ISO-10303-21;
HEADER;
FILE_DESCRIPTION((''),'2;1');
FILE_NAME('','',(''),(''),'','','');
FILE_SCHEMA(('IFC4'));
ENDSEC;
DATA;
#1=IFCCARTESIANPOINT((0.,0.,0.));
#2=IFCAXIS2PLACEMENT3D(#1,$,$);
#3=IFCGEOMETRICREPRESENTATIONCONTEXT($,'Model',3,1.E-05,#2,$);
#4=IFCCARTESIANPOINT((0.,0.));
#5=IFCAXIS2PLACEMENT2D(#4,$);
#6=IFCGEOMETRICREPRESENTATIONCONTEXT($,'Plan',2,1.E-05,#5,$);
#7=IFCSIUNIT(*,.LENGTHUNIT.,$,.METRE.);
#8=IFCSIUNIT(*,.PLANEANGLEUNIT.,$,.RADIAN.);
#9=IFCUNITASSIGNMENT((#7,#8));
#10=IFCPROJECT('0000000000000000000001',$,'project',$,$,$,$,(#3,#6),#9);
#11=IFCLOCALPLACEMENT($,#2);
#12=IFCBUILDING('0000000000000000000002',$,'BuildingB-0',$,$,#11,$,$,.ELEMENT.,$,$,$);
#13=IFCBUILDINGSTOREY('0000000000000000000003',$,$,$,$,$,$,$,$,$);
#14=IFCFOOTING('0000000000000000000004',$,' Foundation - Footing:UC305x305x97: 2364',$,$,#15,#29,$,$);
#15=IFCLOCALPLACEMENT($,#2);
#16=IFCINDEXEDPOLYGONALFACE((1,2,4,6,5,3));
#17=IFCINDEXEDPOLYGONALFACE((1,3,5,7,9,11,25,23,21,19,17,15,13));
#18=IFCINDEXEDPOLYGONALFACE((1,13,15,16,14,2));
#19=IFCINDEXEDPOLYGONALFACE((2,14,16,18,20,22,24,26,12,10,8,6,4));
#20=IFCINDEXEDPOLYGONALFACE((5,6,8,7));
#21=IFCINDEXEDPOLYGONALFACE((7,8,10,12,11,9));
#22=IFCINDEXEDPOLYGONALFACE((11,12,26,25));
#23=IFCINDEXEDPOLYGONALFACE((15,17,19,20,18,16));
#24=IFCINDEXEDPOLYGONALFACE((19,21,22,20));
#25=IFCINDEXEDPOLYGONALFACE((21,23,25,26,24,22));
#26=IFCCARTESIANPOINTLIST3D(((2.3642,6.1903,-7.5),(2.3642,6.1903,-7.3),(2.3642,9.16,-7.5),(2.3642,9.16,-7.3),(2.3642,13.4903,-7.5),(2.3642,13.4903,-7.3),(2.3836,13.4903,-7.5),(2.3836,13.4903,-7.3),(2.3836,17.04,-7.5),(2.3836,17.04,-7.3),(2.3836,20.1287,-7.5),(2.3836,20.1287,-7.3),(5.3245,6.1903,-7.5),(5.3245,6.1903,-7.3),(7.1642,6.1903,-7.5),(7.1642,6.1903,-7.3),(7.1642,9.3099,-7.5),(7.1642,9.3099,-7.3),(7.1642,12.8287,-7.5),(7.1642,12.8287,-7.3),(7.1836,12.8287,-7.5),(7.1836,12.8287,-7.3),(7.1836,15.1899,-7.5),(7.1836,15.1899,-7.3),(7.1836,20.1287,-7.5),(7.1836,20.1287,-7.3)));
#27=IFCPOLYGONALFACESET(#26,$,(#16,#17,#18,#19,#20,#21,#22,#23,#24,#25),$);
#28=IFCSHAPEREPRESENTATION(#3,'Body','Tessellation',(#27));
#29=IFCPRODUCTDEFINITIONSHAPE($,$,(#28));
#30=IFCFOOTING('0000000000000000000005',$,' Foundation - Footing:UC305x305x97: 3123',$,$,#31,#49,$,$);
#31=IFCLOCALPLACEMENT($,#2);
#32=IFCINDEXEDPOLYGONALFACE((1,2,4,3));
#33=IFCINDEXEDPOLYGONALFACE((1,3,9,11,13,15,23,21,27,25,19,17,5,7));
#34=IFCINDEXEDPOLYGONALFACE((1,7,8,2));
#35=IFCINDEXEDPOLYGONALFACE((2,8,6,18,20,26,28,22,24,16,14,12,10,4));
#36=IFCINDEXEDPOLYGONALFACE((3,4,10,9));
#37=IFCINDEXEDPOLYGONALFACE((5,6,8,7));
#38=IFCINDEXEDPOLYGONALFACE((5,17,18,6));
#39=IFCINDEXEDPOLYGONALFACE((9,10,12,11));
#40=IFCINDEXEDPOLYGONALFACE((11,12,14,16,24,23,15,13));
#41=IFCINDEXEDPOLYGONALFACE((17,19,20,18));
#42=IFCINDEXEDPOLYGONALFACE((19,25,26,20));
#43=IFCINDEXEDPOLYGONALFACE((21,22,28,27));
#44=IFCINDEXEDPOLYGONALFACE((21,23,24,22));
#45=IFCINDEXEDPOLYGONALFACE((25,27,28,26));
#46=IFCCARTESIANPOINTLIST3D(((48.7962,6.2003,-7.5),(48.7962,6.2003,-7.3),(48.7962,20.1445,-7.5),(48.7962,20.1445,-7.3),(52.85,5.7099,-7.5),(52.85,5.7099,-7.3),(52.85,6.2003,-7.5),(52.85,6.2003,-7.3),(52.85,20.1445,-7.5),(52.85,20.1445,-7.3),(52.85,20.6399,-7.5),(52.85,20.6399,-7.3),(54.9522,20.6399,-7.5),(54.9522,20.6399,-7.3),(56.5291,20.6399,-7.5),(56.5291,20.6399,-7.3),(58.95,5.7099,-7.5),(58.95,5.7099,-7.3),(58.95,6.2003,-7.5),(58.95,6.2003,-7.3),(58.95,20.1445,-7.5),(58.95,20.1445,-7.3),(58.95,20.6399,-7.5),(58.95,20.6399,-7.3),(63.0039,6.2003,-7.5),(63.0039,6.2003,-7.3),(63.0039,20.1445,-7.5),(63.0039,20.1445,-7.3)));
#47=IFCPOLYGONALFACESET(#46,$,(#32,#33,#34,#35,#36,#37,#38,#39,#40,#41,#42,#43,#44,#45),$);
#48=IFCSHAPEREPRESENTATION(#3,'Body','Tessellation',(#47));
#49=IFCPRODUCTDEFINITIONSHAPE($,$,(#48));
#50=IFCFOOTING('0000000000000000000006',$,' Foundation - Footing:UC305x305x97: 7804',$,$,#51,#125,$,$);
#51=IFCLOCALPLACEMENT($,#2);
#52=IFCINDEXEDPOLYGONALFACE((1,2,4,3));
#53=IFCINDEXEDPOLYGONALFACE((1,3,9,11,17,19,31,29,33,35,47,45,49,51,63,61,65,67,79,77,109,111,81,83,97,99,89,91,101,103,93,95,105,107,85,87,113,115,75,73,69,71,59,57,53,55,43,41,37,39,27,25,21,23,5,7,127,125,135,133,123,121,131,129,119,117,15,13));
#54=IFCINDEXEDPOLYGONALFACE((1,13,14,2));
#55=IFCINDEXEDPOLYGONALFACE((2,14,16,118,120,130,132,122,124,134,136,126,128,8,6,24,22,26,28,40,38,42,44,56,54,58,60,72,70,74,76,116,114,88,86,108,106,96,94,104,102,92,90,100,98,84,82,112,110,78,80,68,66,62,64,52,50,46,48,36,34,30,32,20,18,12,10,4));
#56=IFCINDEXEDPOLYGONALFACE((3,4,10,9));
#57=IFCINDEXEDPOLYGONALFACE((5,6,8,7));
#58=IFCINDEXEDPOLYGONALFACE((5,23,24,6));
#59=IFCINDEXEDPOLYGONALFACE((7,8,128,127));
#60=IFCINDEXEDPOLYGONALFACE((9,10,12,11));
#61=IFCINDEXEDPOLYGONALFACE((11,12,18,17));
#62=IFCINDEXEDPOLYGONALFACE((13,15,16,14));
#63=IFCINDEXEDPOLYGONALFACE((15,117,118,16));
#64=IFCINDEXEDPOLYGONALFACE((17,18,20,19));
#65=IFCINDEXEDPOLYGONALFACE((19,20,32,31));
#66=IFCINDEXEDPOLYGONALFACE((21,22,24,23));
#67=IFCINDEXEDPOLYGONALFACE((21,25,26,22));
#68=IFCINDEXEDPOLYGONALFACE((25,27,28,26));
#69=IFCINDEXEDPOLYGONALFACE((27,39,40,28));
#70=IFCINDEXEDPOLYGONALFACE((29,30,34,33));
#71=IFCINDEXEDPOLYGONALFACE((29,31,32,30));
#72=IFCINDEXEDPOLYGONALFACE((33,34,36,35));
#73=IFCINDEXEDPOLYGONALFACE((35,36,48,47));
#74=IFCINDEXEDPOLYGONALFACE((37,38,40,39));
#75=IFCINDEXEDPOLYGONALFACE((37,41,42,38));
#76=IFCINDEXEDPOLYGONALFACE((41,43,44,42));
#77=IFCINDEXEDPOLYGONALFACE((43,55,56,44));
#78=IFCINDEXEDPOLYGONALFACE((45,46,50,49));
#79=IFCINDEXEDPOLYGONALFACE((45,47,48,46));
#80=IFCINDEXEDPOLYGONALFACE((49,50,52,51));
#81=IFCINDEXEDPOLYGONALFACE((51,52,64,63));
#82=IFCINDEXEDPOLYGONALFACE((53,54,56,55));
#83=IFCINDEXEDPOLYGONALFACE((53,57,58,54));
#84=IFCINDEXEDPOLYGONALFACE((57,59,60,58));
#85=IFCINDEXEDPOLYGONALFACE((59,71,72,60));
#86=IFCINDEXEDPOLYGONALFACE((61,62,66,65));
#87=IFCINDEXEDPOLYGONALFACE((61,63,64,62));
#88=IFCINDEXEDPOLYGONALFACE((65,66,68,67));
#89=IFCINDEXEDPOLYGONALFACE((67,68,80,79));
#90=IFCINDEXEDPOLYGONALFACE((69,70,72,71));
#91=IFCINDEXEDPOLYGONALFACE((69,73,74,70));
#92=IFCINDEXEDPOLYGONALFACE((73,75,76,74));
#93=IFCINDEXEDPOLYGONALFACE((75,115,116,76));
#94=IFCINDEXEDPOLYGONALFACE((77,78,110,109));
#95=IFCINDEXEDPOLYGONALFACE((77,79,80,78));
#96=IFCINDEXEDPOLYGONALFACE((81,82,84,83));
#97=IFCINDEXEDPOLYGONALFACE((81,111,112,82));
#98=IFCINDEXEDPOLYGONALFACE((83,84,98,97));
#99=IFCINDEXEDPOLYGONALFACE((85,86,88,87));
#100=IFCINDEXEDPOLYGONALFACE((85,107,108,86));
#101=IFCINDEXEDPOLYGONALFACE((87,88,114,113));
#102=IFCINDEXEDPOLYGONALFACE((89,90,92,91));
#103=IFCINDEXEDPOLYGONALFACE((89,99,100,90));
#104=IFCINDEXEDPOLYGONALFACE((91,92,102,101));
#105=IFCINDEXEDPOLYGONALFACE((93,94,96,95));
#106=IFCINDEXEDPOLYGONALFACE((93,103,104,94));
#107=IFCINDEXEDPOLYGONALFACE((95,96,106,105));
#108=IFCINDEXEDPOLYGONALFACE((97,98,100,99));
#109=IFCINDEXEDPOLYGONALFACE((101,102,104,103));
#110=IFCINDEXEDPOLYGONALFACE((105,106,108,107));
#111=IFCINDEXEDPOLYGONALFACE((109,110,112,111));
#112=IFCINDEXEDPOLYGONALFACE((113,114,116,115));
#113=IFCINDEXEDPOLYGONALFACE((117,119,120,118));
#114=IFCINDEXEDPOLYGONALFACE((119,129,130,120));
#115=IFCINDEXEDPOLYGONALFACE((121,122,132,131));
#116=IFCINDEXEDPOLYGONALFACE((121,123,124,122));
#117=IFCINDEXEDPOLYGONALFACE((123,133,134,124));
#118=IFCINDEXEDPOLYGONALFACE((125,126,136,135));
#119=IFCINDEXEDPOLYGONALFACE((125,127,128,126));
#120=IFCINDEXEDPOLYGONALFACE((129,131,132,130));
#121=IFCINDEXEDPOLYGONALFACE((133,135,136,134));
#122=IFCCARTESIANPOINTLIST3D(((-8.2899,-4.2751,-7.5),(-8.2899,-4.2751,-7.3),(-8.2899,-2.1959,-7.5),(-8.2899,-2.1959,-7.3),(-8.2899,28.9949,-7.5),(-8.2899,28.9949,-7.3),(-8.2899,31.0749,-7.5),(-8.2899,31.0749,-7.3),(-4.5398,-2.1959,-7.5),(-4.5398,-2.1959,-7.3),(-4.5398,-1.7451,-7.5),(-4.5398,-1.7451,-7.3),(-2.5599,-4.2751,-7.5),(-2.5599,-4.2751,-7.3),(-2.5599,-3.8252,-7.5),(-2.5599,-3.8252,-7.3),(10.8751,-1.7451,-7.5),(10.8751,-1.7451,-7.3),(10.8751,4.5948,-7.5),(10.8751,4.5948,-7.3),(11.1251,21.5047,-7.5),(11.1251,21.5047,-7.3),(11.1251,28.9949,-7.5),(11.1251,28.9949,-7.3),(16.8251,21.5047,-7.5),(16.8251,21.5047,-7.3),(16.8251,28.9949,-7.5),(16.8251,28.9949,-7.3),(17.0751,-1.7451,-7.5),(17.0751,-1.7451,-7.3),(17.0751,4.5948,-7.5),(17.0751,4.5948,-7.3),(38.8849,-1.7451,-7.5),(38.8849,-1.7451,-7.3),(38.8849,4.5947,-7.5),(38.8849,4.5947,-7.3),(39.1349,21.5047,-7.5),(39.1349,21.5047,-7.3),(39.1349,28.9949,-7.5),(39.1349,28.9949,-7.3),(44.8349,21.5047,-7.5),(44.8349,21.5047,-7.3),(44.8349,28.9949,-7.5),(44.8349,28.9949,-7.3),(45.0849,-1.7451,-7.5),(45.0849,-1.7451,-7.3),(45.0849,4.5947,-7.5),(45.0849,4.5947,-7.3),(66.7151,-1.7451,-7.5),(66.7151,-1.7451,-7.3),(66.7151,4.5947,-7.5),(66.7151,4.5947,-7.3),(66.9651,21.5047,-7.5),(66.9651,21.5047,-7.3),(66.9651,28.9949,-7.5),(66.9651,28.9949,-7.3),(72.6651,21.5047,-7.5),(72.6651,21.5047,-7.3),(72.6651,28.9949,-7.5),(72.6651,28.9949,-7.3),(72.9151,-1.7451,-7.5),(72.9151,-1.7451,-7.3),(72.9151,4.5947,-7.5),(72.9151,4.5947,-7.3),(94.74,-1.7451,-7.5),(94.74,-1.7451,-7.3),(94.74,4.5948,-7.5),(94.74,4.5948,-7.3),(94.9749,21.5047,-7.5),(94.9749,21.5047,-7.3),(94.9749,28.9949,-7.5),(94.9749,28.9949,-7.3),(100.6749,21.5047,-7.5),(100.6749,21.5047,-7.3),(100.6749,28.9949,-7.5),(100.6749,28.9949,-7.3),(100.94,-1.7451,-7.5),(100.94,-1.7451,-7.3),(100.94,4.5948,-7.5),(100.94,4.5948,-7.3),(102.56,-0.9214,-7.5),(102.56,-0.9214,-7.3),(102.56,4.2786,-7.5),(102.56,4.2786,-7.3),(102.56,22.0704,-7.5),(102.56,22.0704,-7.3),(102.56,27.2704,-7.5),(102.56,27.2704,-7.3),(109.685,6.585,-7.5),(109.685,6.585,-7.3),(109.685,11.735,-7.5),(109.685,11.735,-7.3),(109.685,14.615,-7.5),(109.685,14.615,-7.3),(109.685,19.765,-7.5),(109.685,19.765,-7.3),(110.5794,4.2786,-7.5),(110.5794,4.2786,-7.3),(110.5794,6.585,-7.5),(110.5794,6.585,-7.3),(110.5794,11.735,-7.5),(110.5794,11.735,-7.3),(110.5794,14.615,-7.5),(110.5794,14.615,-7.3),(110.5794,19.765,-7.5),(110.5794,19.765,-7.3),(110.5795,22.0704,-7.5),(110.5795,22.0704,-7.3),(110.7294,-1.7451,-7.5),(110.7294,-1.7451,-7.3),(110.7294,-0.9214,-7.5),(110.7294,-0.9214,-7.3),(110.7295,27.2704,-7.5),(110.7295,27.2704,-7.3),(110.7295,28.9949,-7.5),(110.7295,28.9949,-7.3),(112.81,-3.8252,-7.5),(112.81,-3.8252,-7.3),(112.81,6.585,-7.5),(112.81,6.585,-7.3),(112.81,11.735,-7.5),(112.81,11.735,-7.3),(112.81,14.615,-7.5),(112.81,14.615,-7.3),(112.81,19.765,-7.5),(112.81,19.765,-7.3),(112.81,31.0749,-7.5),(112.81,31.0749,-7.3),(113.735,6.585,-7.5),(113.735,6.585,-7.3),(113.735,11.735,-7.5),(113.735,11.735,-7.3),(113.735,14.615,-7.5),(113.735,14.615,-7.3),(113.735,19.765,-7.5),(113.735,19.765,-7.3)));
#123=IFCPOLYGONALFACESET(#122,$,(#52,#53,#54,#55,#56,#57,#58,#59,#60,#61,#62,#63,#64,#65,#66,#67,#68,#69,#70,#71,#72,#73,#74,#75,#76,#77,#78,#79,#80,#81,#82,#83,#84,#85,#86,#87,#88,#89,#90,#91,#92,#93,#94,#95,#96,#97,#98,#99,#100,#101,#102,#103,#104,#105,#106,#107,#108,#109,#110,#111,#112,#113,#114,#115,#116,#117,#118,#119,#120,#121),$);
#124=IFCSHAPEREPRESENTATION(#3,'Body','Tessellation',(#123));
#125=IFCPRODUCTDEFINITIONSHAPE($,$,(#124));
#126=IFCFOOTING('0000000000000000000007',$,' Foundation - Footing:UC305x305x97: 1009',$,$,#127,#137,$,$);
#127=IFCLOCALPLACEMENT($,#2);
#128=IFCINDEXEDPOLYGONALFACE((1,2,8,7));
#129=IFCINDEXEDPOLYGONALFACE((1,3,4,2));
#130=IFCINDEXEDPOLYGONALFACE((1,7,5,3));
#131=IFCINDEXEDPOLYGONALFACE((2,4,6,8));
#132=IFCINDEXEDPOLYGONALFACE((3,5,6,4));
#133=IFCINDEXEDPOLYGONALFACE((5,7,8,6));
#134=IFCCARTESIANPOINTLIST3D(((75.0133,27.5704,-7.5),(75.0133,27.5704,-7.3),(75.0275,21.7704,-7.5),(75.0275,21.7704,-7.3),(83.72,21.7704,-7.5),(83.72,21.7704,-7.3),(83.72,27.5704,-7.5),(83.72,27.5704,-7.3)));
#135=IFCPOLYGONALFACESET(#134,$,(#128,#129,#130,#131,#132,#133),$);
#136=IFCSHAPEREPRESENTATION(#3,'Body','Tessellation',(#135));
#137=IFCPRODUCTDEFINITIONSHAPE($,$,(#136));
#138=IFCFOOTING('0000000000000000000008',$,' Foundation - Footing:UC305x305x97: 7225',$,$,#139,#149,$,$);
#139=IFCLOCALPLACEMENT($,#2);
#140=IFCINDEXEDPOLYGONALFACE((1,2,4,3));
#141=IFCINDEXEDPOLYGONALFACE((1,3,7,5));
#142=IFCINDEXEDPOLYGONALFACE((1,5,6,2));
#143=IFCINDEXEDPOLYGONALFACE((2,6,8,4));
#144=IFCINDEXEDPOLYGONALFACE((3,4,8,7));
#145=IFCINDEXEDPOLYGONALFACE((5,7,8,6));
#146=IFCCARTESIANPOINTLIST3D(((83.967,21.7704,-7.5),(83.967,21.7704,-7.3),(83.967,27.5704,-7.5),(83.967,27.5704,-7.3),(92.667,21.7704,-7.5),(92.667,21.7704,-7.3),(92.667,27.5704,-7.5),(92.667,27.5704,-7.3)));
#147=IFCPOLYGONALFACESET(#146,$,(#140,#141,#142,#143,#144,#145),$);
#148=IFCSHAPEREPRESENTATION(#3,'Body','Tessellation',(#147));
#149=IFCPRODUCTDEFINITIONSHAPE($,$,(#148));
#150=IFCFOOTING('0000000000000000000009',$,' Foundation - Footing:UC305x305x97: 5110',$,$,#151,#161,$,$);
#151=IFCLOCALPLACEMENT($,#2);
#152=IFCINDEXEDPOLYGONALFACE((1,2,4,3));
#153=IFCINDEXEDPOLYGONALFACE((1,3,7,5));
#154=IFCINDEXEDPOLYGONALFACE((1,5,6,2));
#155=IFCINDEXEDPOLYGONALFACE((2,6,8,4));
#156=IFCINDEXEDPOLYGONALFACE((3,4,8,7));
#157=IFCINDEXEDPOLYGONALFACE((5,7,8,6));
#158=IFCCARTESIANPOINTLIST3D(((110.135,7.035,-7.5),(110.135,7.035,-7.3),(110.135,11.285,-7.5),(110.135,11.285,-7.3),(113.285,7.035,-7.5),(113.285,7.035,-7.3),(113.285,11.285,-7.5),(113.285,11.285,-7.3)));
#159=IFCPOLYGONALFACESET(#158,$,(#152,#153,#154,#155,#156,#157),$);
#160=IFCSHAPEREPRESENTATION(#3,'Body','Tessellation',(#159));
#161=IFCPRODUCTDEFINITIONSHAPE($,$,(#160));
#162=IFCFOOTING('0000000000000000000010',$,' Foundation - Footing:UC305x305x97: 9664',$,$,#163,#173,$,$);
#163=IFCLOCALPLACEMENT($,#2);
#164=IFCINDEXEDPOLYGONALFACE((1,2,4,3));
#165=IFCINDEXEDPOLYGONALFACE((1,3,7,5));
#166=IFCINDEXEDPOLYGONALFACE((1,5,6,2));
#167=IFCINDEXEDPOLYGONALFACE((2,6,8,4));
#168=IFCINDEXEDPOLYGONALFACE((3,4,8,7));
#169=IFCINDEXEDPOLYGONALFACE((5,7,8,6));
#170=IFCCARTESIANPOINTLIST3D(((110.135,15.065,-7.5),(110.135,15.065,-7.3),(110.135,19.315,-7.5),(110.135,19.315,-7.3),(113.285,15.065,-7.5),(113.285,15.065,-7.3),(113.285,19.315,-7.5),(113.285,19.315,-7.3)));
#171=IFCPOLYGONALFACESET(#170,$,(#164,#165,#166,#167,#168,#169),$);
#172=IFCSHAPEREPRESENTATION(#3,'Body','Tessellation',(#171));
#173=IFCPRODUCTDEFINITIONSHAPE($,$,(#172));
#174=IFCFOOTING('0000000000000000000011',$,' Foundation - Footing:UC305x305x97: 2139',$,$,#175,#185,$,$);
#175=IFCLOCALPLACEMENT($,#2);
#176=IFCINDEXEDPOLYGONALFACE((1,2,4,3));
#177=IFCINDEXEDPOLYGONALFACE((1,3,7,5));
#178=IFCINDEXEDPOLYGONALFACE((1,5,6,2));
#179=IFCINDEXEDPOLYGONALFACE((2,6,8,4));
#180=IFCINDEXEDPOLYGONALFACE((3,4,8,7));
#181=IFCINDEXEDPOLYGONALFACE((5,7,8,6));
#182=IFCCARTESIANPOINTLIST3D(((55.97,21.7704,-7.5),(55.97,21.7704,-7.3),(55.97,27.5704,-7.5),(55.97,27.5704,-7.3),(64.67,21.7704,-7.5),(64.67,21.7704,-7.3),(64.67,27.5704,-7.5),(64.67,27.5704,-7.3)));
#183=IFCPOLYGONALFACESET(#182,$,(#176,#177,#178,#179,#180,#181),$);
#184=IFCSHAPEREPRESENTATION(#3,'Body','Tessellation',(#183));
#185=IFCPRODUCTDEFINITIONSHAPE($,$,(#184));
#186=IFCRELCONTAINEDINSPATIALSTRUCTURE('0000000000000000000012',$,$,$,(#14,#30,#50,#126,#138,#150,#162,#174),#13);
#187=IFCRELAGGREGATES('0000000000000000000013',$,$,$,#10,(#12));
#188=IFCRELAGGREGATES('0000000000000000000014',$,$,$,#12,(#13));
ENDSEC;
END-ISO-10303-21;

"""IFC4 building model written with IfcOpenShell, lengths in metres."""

from ifc_helpers import new_model, si_unit, origin, origin_2d, place, context, project, spatial, polyline, outline, extrude, element, save


model = new_model("IFC4")

# Units and contexts
model_context = context("Model", 3, precision=1e-05, world=origin())
plan_context = context("Plan", 2, precision=1e-05, world=origin_2d())
ifc_project = project(units=[si_unit("LENGTHUNIT", "METRE"), si_unit("PLANEANGLEUNIT", "RADIAN")], contexts=[model_context, plan_context])

# Building, storey
building_placement = place(None, origin())
building = spatial("IfcBuilding", under=ifc_project, at=building_placement, Name="BuildingB-0", CompositionType="ELEMENT")
storey = spatial("IfcBuildingStorey", under=building)

# Footings
element("IfcFooting", 1, inside=storey, Name=" Foundation - Footing:UC305x305x97: 2364", context=model_context, shape_type="SweptSolid", body=[
    extrude(outline(polyline([(7.1642, 12.8287, -7.5), (7.1836, 12.8287, -7.5), (7.1836, 15.1899, -7.5), (7.1836, 20.1287, -7.5), (2.3836, 20.1287, -7.5), (2.3836, 17.04, -7.5), (2.3836, 13.4903, -7.5), (2.3642, 13.4903, -7.5), (2.3642, 9.16, -7.5), (2.3642, 6.1903, -7.5), (5.3245, 6.1903, -7.5), (7.1642, 6.1903, -7.5), (7.1642, 9.3099, -7.5), (7.1642, 12.8287, -7.5)])), None, (0.0, 0.0, 1.0), 0.2),
])
element("IfcFooting", 2, inside=storey, Name=" Foundation - Footing:UC305x305x97: 3123", context=model_context, shape_type="SweptSolid", body=[
    extrude(outline(polyline([(58.95, 5.7099, -7.5), (58.95, 6.2003, -7.5), (63.0039, 6.2003, -7.5), (63.0039, 20.1445, -7.5), (58.95, 20.1445, -7.5), (58.95, 20.6399, -7.5), (56.5291, 20.6399, -7.5), (54.9522, 20.6399, -7.5), (52.85, 20.6399, -7.5), (52.85, 20.1445, -7.5), (48.7962, 20.1445, -7.5), (48.7962, 6.2003, -7.5), (52.85, 6.2003, -7.5), (52.85, 5.7099, -7.5), (58.95, 5.7099, -7.5)])), None, (0.0, 0.0, 1.0), 0.2),
])
element("IfcFooting", 3, inside=storey, Name=" Foundation - Footing:UC305x305x97: 7804", context=model_context, shape_type="SweptSolid", body=[
    extrude(outline(polyline([(-8.2899, 31.0749, -7.5), (-8.2899, 28.9949, -7.5), (11.1251, 28.9949, -7.5), (11.1251, 21.5047, -7.5), (16.8251, 21.5047, -7.5), (16.8251, 28.9949, -7.5), (39.1349, 28.9949, -7.5), (39.1349, 21.5047, -7.5), (44.8349, 21.5047, -7.5), (44.8349, 28.9949, -7.5), (66.9651, 28.9949, -7.5), (66.9651, 21.5047, -7.5), (72.6651, 21.5047, -7.5), (72.6651, 28.9949, -7.5), (94.9749, 28.9949, -7.5), (94.9749, 21.5047, -7.5), (100.6749, 21.5047, -7.5), (100.6749, 28.9949, -7.5), (110.7295, 28.9949, -7.5), (110.7295, 27.2704, -7.5), (102.56, 27.2704, -7.5), (102.56, 22.0704, -7.5), (110.5795, 22.0704, -7.5), (110.5794, 19.765, -7.5), (109.685, 19.765, -7.5), (109.685, 14.615, -7.5), (110.5794, 14.615, -7.5), (110.5794, 11.735, -7.5), (109.685, 11.735, -7.5), (109.685, 6.585, -7.5), (110.5794, 6.585, -7.5), (110.5794, 4.2786, -7.5), (102.56, 4.2786, -7.5), (102.56, -0.9214, -7.5), (110.7294, -0.9214, -7.5), (110.7294, -1.7451, -7.5), (100.94, -1.7451, -7.5), (100.94, 4.5948, -7.5), (94.74, 4.5948, -7.5), (94.74, -1.7451, -7.5), (72.9151, -1.7451, -7.5), (72.9151, 4.5947, -7.5), (66.7151, 4.5947, -7.5), (66.7151, -1.7451, -7.5), (45.0849, -1.7451, -7.5), (45.0849, 4.5947, -7.5), (38.8849, 4.5947, -7.5), (38.8849, -1.7451, -7.5), (17.0751, -1.7451, -7.5), (17.0751, 4.5948, -7.5), (10.8751, 4.5948, -7.5), (10.8751, -1.7451, -7.5), (-4.5398, -1.7451, -7.5), (-4.5398, -2.1959, -7.5), (-8.2899, -2.1959, -7.5), (-8.2899, -4.2751, -7.5), (-2.5599, -4.2751, -7.5), (-2.5599, -3.8252, -7.5), (112.81, -3.8252, -7.5), (112.81, 6.585, -7.5), (113.735, 6.585, -7.5), (113.735, 11.735, -7.5), (112.81, 11.735, -7.5), (112.81, 14.615, -7.5), (113.735, 14.615, -7.5), (113.735, 19.765, -7.5), (112.81, 19.765, -7.5), (112.81, 31.0749, -7.5), (-8.2899, 31.0749, -7.5)])), None, (0.0, 0.0, 1.0), 0.2),
])
element("IfcFooting", 4, inside=storey, Name=" Foundation - Footing:UC305x305x97: 1009", context=model_context, shape_type="SweptSolid", body=[
    extrude(outline(polyline([(75.0275, 21.7704, -7.5), (83.72, 21.7704, -7.5), (83.72, 27.5704, -7.5), (75.0133, 27.5704, -7.5), (75.0275, 21.7704, -7.5)])), None, (0.0, 0.0, 1.0), 0.2),
])
element("IfcFooting", 5, inside=storey, Name=" Foundation - Footing:UC305x305x97: 7225", context=model_context, shape_type="SweptSolid", body=[
    extrude(outline(polyline([(83.967, 21.7704, -7.5), (92.667, 21.7704, -7.5), (92.667, 27.5704, -7.5), (83.967, 27.5704, -7.5), (83.967, 21.7704, -7.5)])), None, (0.0, 0.0, 1.0), 0.2),
])
element("IfcFooting", 6, inside=storey, Name=" Foundation - Footing:UC305x305x97: 5110", context=model_context, shape_type="SweptSolid", body=[
    extrude(outline(polyline([(110.135, 11.285, -7.5), (113.285, 11.285, -7.5), (113.285, 7.035, -7.5), (110.135, 7.035, -7.5), (110.135, 11.285, -7.5)])), None, (0.0, 0.0, 1.0), 0.2),
])
element("IfcFooting", 7, inside=storey, Name=" Foundation - Footing:UC305x305x97: 9664", context=model_context, shape_type="SweptSolid", body=[
    extrude(outline(polyline([(110.135, 19.315, -7.5), (113.285, 19.315, -7.5), (113.285, 15.065, -7.5), (110.135, 15.065, -7.5), (110.135, 19.315, -7.5)])), None, (0.0, 0.0, 1.0), 0.2),
])
element("IfcFooting", 8, inside=storey, Name=" Foundation - Footing:UC305x305x97: 2139", context=model_context, shape_type="SweptSolid", body=[
    extrude(outline(polyline([(55.97, 27.5704, -7.5), (64.67, 27.5704, -7.5), (64.67, 21.7704, -7.5), (55.97, 21.7704, -7.5), (55.97, 27.5704, -7.5)])), None, (0.0, 0.0, 1.0), 0.2),
])

save(model, "model.ifc")
